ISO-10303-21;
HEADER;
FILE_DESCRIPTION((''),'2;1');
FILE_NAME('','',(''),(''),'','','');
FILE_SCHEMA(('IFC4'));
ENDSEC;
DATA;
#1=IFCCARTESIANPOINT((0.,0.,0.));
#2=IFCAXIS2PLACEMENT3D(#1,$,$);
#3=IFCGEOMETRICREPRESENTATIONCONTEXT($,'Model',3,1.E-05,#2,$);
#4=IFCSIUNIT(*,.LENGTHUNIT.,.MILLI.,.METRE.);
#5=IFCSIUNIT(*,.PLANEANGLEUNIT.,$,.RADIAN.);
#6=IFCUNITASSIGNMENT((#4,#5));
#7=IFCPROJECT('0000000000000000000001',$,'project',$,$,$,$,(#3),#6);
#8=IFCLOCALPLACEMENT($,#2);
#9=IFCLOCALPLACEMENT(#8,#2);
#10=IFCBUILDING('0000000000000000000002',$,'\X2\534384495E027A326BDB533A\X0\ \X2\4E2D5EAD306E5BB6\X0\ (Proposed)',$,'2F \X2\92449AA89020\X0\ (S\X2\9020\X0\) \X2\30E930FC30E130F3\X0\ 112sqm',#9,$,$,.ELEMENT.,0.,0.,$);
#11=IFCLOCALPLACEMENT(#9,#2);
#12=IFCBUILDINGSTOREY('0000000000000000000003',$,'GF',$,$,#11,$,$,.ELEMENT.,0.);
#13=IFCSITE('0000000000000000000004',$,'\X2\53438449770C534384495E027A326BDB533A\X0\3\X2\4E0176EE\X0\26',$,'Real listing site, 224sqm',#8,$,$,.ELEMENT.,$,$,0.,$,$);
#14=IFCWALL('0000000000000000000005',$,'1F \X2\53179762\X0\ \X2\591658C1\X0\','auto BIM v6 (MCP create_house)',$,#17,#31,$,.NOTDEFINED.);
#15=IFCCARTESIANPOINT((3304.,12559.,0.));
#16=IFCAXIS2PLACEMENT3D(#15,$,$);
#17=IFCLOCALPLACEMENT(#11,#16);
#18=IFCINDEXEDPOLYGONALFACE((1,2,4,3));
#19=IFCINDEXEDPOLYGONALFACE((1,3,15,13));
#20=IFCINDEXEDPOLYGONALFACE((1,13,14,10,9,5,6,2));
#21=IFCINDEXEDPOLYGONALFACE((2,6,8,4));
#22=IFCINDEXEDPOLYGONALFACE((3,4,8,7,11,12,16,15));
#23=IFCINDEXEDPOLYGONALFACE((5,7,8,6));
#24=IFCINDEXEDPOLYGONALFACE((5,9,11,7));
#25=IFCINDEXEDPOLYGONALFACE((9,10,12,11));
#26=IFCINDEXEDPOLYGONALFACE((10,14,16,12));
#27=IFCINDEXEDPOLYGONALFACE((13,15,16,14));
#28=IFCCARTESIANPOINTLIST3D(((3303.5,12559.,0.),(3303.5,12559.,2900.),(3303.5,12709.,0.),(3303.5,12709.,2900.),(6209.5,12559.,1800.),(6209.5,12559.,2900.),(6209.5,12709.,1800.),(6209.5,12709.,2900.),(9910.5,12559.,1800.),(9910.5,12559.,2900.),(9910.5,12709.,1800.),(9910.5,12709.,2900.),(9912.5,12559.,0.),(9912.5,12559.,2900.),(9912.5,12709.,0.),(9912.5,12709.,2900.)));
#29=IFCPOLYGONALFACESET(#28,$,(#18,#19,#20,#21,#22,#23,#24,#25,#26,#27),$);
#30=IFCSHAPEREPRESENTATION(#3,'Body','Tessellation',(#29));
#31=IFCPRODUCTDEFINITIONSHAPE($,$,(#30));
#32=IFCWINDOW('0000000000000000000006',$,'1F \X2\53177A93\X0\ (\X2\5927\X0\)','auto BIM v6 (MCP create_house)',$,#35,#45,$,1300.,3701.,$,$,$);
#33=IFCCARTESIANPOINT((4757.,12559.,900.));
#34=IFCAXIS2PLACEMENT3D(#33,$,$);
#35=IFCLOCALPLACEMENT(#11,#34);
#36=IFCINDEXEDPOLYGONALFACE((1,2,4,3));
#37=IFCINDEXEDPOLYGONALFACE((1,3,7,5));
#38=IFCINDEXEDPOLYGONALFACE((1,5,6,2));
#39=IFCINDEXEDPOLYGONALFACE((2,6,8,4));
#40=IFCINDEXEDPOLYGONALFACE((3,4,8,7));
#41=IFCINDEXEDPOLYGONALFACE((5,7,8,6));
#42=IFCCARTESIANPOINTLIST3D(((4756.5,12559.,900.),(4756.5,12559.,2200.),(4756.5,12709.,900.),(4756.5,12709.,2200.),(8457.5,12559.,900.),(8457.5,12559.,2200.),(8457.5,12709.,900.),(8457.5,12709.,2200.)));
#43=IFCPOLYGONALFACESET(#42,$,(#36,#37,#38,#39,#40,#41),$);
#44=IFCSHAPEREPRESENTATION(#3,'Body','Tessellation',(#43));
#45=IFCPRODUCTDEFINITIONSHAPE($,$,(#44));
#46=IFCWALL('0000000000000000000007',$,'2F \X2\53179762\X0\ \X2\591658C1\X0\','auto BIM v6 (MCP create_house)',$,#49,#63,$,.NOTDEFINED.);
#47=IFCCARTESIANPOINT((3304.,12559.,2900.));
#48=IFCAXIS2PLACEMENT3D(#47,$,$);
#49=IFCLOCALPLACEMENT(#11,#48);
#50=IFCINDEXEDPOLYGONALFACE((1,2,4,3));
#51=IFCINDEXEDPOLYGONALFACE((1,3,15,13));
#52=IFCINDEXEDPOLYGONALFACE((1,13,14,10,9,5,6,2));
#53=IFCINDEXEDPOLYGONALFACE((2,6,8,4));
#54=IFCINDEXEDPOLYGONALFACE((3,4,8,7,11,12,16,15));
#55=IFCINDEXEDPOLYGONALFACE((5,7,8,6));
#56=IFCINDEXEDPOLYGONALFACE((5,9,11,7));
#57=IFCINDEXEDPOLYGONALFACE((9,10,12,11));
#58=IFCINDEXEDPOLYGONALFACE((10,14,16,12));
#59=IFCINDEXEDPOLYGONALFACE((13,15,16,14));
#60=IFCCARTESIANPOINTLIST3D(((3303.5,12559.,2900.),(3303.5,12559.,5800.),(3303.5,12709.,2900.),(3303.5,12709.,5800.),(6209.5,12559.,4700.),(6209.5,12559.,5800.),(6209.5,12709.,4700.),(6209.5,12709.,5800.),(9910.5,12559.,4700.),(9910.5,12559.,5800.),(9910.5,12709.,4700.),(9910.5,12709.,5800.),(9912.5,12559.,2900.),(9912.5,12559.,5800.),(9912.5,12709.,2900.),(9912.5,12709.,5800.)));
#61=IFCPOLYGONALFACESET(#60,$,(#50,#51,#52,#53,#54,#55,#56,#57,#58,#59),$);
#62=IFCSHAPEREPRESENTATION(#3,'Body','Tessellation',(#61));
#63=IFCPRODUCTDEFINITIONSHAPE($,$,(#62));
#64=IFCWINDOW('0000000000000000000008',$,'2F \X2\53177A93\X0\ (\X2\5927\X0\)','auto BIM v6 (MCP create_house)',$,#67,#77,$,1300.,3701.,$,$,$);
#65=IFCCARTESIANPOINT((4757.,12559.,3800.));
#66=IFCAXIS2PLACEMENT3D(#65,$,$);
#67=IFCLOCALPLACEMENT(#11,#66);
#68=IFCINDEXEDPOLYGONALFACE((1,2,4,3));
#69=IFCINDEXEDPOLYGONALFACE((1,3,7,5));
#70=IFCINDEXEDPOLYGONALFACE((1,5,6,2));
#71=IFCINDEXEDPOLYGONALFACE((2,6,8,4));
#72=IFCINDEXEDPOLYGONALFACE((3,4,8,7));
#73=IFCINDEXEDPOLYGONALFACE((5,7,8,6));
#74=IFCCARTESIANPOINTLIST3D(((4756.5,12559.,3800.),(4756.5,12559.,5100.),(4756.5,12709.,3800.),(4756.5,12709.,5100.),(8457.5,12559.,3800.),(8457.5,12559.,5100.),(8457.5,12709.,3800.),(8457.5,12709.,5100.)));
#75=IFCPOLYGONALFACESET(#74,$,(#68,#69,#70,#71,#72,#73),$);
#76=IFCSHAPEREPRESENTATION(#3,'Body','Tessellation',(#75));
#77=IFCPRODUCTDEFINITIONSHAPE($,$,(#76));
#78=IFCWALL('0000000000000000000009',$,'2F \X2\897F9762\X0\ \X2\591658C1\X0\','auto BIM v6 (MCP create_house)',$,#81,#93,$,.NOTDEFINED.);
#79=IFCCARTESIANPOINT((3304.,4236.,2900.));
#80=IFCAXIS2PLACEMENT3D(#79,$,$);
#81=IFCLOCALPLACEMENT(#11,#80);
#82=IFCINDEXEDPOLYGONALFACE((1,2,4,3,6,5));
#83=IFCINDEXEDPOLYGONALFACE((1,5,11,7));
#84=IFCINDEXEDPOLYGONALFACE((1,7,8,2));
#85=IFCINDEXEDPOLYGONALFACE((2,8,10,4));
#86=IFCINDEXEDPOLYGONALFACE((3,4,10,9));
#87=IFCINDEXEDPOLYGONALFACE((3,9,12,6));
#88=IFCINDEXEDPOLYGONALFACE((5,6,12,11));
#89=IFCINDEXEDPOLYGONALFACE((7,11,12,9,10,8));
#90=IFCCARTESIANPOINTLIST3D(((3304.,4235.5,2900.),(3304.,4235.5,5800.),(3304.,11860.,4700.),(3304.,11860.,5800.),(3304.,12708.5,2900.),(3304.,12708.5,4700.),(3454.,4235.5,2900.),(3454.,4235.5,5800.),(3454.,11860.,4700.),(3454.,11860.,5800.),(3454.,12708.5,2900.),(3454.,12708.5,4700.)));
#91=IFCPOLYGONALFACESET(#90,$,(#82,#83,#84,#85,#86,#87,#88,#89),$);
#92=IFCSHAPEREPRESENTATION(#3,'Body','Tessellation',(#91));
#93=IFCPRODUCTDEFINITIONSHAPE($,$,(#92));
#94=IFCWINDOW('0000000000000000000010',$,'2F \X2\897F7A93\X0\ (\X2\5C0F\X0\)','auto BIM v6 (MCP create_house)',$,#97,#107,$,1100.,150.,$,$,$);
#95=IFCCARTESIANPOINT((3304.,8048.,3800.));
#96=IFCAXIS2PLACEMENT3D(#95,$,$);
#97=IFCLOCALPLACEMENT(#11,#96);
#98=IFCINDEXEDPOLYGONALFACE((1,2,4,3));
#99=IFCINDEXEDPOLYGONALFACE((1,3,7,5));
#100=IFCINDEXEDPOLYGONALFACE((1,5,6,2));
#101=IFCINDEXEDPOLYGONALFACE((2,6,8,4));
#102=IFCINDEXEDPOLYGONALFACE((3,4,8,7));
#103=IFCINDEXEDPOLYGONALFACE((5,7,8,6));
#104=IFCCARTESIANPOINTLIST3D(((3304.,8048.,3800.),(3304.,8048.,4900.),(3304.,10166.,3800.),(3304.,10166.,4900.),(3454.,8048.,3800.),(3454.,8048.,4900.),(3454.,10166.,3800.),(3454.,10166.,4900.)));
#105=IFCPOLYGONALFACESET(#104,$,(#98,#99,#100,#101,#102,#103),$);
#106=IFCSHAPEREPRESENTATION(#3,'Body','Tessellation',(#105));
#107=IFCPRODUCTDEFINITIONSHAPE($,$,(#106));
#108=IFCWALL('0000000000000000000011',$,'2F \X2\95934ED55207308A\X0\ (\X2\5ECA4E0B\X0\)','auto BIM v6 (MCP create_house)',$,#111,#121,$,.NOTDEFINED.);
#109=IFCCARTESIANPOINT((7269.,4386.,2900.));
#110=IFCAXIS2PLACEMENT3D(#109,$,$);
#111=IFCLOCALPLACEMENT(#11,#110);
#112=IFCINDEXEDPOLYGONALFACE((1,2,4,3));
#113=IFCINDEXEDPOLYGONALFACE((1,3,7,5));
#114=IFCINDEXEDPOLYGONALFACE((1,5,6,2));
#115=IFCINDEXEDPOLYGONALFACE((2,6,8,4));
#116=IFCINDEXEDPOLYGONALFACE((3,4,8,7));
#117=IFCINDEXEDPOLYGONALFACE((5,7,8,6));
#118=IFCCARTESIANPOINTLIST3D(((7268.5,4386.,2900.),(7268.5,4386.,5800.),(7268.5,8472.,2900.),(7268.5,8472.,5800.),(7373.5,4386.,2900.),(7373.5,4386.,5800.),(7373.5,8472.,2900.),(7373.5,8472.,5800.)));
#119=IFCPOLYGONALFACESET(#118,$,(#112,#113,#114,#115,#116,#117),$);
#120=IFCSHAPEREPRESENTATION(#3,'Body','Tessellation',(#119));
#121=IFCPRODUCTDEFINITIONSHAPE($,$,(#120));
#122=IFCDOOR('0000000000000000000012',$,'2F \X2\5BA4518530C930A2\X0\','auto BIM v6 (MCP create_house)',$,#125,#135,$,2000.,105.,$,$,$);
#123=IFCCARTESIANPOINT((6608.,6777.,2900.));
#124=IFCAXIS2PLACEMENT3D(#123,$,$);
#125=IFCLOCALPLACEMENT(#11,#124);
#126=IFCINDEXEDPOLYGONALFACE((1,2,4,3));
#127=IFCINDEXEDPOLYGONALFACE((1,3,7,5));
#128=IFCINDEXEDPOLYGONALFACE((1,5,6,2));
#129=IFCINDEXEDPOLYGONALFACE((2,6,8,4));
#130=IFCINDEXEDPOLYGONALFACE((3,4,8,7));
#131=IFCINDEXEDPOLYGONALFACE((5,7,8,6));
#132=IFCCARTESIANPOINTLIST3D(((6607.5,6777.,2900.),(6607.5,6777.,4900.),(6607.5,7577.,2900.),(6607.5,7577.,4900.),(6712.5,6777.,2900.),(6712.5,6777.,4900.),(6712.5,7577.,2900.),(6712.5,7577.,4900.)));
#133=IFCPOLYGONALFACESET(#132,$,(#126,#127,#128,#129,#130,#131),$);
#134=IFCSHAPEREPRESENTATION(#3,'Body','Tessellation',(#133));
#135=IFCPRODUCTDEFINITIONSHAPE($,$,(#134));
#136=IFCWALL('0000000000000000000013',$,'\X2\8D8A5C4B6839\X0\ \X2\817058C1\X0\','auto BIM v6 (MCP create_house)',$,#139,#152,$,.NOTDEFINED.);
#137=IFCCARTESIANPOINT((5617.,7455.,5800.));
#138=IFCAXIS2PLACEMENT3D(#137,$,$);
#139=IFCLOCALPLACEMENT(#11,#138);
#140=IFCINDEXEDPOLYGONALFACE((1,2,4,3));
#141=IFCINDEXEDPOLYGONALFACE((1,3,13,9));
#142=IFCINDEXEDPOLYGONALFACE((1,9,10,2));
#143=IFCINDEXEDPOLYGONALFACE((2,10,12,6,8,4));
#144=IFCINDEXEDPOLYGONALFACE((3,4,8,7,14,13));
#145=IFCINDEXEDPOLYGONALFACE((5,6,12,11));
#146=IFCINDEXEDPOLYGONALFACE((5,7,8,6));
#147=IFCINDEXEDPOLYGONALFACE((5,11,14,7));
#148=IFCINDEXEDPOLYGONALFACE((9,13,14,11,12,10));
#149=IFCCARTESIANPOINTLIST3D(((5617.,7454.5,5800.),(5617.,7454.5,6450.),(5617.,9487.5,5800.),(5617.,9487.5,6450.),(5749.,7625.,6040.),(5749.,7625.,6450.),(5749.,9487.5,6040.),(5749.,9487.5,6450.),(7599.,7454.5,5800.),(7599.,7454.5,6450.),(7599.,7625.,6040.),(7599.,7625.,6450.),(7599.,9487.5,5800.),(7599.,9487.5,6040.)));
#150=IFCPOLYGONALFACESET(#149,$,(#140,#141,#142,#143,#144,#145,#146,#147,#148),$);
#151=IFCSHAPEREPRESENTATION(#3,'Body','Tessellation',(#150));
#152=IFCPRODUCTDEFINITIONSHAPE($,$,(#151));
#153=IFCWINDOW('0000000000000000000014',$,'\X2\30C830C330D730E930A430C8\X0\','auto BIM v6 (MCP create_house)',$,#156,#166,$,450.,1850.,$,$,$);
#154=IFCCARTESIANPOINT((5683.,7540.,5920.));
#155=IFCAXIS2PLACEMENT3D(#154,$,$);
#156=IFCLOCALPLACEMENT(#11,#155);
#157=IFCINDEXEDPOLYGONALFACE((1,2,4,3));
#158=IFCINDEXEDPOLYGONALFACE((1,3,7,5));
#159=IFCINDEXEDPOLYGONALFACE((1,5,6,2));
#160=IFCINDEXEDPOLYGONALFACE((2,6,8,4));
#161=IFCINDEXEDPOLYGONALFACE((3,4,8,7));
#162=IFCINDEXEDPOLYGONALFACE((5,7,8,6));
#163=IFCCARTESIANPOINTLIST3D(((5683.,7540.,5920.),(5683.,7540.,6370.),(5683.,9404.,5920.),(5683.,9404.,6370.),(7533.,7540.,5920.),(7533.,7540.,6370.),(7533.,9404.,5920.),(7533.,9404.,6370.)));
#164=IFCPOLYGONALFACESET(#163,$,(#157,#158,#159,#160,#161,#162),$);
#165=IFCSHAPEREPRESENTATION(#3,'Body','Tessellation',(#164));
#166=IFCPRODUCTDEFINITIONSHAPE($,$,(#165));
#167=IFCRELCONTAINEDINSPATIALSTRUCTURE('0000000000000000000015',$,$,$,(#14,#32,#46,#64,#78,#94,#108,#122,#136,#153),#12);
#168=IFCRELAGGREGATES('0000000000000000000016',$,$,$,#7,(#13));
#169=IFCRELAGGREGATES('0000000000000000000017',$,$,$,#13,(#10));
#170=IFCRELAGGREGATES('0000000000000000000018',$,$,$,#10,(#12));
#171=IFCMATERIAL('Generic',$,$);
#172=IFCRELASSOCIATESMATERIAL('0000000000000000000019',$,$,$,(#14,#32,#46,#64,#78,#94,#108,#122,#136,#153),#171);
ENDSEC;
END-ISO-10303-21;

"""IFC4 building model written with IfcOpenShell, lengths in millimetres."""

from ifc_helpers import new_model, si_unit, frame, frame_2d, origin, place, context, project, spatial, rectangle, extrude, material, element, fill, save


model = new_model("IFC4")

# Units and contexts
model_context = context("Model", 3, precision=1e-05, world=origin())
ifc_project = project(units=[si_unit("LENGTHUNIT", "METRE", prefix="MILLI"), si_unit("PLANEANGLEUNIT", "RADIAN")], contexts=[model_context])

# Site, building, storey
site_placement = place(None, origin())
site = spatial("IfcSite", under=ifc_project, at=site_placement, Name="千葉県千葉市稲毛区3丁目26", ObjectType="Real listing site, 224sqm", CompositionType="ELEMENT", RefElevation=0.0)
building_placement = place(site_placement, origin())
building = spatial("IfcBuilding", under=site, at=building_placement, Name="千葉市稲毛区 中庭の家 (Proposed)", ObjectType="2F 鉄骨造 (S造) ラーメン 112sqm", CompositionType="ELEMENT", ElevationOfRefHeight=0.0, ElevationOfTerrain=0.0)
storey_placement = place(building_placement, origin())
storey = spatial("IfcBuildingStorey", under=building, at=storey_placement, Name="GF", CompositionType="ELEMENT", Elevation=0.0)

# Wall, opening, window
ifc_material = material(Name="Generic")
wall_1_placement = place(storey_placement, frame((3304.0, 12559.0, 0.0)))
wall_1 = element("IfcWall", 1, at=wall_1_placement, inside=storey, material=ifc_material, Name="1F 北面 外壁", Description="auto BIM v6 (MCP create_house)", PredefinedType="NOTDEFINED", context=model_context, shape_type="SweptSolid", body=[
    extrude(rectangle(XDim=6609.0, YDim=150.0, at=frame_2d((3304.0, 75.0))), frame((3304.0, 12559.0, 0.0)), (0.0, 0.0, 1.0), 2900.0),
])
opening_1_placement = place(storey_placement, frame((4757.0, 12559.0, 900.0)))
opening_1 = element("IfcOpeningElement", 2, at=opening_1_placement, cuts=wall_1, PredefinedType="NOTDEFINED", context=model_context, shape_type="SweptSolid", body=[
    extrude(rectangle(XDim=3701.0, YDim=150.0, at=frame_2d((1850.0, 75.0))), frame((4757.0, 12559.0, 900.0)), (0.0, 0.0, 1.0), 1300.0),
])
window_1_placement = place(storey_placement, frame((4757.0, 12559.0, 900.0)))
window_1 = element("IfcWindow", 3, at=window_1_placement, inside=storey, material=ifc_material, Name="1F 北窓 (大)", Description="auto BIM v6 (MCP create_house)", OverallHeight=1300.0, OverallWidth=3701.0, context=model_context, shape_type="SweptSolid", body=[
    extrude(rectangle(XDim=3701.0, YDim=150.0, at=frame_2d((1850.0, 75.0))), frame((4757.0, 12559.0, 900.0)), (0.0, 0.0, 1.0), 1300.0),
])
fill(opening_1, window_1)

# Walls, openings, windows
wall_2_placement = place(storey_placement, frame((3304.0, 12559.0, 2900.0)))
wall_2 = element("IfcWall", 4, at=wall_2_placement, inside=storey, material=ifc_material, Name="2F 北面 外壁", Description="auto BIM v6 (MCP create_house)", PredefinedType="NOTDEFINED", context=model_context, shape_type="SweptSolid", body=[
    extrude(rectangle(XDim=6609.0, YDim=150.0, at=frame_2d((3304.0, 75.0))), frame((3304.0, 12559.0, 2900.0)), (0.0, 0.0, 1.0), 2900.0),
])
opening_2_placement = place(storey_placement, frame((4757.0, 12559.0, 3800.0)))
opening_2 = element("IfcOpeningElement", 5, at=opening_2_placement, cuts=wall_2, PredefinedType="NOTDEFINED", context=model_context, shape_type="SweptSolid", body=[
    extrude(rectangle(XDim=3701.0, YDim=150.0, at=frame_2d((1850.0, 75.0))), frame((4757.0, 12559.0, 3800.0)), (0.0, 0.0, 1.0), 1300.0),
])
window_2_placement = place(storey_placement, frame((4757.0, 12559.0, 3800.0)))
window_2 = element("IfcWindow", 6, at=window_2_placement, inside=storey, material=ifc_material, Name="2F 北窓 (大)", Description="auto BIM v6 (MCP create_house)", OverallHeight=1300.0, OverallWidth=3701.0, context=model_context, shape_type="SweptSolid", body=[
    extrude(rectangle(XDim=3701.0, YDim=150.0, at=frame_2d((1850.0, 75.0))), frame((4757.0, 12559.0, 3800.0)), (0.0, 0.0, 1.0), 1300.0),
])
fill(opening_2, window_2)
wall_3_placement = place(storey_placement, frame((3304.0, 4236.0, 2900.0)))
wall_3 = element("IfcWall", 7, at=wall_3_placement, inside=storey, material=ifc_material, Name="2F 西面 外壁", Description="auto BIM v6 (MCP create_house)", PredefinedType="NOTDEFINED", context=model_context, shape_type="SweptSolid", body=[
    extrude(rectangle(XDim=150.0, YDim=8473.0, at=frame_2d((75.0, 4236.0))), frame((3304.0, 4236.0, 2900.0)), (0.0, 0.0, 1.0), 2900.0),
])
opening_3_placement = place(storey_placement, frame((3304.0, 8048.0, 3800.0)))
opening_3 = element("IfcOpeningElement", 8, at=opening_3_placement, cuts=wall_3, PredefinedType="NOTDEFINED", context=model_context, shape_type="SweptSolid", body=[
    extrude(rectangle(XDim=150.0, YDim=2118.0, at=frame_2d((75.0, 1059.0))), frame((3304.0, 8048.0, 3800.0)), (0.0, 0.0, 1.0), 1100.0),
])
window_3_placement = place(storey_placement, frame((3304.0, 8048.0, 3800.0)))
window_3 = element("IfcWindow", 9, at=window_3_placement, inside=storey, material=ifc_material, Name="2F 西窓 (小)", Description="auto BIM v6 (MCP create_house)", OverallHeight=1100.0, OverallWidth=150.0, context=model_context, shape_type="SweptSolid", body=[
    extrude(rectangle(XDim=150.0, YDim=2118.0, at=frame_2d((75.0, 1059.0))), frame((3304.0, 8048.0, 3800.0)), (0.0, 0.0, 1.0), 1100.0),
])
fill(opening_3, window_3)

# Wall
wall_4_placement = place(storey_placement, frame((7269.0, 4386.0, 2900.0)))
element("IfcWall", 10, at=wall_4_placement, inside=storey, material=ifc_material, Name="2F 間仕切り (廊下)", Description="auto BIM v6 (MCP create_house)", PredefinedType="NOTDEFINED", context=model_context, shape_type="SweptSolid", body=[
    extrude(rectangle(XDim=105.0, YDim=4086.0, at=frame_2d((52.0, 2043.0))), frame((7269.0, 4386.0, 2900.0)), (0.0, 0.0, 1.0), 2900.0),
])

# Door
door_placement = place(storey_placement, frame((6608.0, 6777.0, 2900.0)))
element("IfcDoor", 11, at=door_placement, inside=storey, material=ifc_material, Name="2F 室内ドア", Description="auto BIM v6 (MCP create_house)", OverallHeight=2000.0, OverallWidth=105.0, context=model_context, shape_type="SweptSolid", body=[
    extrude(rectangle(XDim=105.0, YDim=800.0, at=frame_2d((52.0, 400.0))), frame((6608.0, 6777.0, 2900.0)), (0.0, 0.0, 1.0), 2000.0),
])

# Wall, opening, window
wall_5_placement = place(storey_placement, frame((5617.0, 7455.0, 5800.0)))
wall_5 = element("IfcWall", 12, at=wall_5_placement, inside=storey, material=ifc_material, Name="越屋根 腰壁", Description="auto BIM v6 (MCP create_house)", PredefinedType="NOTDEFINED", context=model_context, shape_type="SweptSolid", body=[
    extrude(rectangle(XDim=1982.0, YDim=2033.0, at=frame_2d((991.0, 1016.0))), frame((5617.0, 7455.0, 5800.0)), (0.0, 0.0, 1.0), 650.0),
])
opening_4_placement = place(storey_placement, frame((5683.0, 7540.0, 5920.0)))
opening_4 = element("IfcOpeningElement", 13, at=opening_4_placement, cuts=wall_5, PredefinedType="NOTDEFINED", context=model_context, shape_type="SweptSolid", body=[
    extrude(rectangle(XDim=1850.0, YDim=1864.0, at=frame_2d((925.0, 932.0))), frame((5683.0, 7540.0, 5920.0)), (0.0, 0.0, 1.0), 450.0),
])
window_4_placement = place(storey_placement, frame((5683.0, 7540.0, 5920.0)))
window_4 = element("IfcWindow", 14, at=window_4_placement, inside=storey, material=ifc_material, Name="トップライト", Description="auto BIM v6 (MCP create_house)", OverallHeight=450.0, OverallWidth=1850.0, context=model_context, shape_type="SweptSolid", body=[
    extrude(rectangle(XDim=1850.0, YDim=1864.0, at=frame_2d((925.0, 932.0))), frame((5683.0, 7540.0, 5920.0)), (0.0, 0.0, 1.0), 450.0),
])
fill(opening_4, window_4)

save(model, "model.ifc")
